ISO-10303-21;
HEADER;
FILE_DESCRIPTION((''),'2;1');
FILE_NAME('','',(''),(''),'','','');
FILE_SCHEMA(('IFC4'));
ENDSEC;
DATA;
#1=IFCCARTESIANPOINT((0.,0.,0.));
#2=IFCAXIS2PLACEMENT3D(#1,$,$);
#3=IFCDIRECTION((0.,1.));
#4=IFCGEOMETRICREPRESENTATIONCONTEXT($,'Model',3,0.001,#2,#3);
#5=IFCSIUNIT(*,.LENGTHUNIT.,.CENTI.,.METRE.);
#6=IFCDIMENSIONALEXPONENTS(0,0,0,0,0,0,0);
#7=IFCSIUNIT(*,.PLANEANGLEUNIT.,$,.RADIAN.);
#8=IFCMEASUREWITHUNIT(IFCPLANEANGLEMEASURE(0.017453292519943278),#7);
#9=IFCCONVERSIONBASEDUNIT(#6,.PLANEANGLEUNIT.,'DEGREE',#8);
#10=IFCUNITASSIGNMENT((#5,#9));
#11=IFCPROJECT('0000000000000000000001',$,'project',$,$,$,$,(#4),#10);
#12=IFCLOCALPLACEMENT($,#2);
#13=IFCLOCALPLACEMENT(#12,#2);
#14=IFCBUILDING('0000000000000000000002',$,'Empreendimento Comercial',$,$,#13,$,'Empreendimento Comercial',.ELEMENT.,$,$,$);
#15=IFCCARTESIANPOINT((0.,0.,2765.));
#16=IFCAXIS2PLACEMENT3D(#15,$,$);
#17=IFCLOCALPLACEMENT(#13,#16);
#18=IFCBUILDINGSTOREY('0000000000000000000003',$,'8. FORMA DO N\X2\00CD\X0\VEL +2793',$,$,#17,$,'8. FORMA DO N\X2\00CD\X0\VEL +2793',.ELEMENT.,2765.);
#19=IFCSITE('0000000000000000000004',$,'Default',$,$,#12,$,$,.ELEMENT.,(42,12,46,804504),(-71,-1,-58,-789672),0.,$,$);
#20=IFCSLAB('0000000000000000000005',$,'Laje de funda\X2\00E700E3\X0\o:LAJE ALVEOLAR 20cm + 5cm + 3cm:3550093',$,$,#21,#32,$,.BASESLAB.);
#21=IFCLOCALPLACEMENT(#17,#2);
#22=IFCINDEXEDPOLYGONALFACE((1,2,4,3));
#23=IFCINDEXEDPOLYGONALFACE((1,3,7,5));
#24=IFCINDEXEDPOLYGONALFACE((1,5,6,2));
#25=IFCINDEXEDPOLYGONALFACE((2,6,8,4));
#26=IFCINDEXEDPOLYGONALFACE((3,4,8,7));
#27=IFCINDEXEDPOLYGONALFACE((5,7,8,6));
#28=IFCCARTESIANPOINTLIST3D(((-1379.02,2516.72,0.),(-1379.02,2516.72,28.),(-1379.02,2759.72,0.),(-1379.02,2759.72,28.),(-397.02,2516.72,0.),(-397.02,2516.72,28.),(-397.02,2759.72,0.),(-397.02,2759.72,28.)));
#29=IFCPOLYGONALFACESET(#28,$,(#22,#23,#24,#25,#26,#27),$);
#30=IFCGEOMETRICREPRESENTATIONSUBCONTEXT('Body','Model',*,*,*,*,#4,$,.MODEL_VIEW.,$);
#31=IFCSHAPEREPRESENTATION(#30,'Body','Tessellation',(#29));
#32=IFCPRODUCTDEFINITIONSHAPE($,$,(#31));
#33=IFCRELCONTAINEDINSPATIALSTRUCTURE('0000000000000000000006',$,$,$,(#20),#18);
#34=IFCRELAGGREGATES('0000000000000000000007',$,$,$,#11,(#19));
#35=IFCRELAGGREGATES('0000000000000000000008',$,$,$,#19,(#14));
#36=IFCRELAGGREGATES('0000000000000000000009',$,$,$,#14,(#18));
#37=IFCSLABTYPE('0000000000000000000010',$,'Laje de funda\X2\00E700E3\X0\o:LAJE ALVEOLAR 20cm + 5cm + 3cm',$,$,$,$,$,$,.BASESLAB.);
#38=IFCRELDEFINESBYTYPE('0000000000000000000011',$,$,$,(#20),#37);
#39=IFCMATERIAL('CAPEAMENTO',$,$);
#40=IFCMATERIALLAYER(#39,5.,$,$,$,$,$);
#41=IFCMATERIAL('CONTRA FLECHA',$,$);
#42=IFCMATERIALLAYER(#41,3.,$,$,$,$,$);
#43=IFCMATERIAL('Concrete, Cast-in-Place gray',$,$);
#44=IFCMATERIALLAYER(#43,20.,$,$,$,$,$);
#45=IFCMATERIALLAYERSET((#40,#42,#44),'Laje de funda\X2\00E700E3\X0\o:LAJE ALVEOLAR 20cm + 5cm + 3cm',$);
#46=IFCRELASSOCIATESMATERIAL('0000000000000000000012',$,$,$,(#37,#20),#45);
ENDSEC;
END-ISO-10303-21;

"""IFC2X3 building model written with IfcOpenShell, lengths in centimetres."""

from ifc_helpers import new_model, entity, si_unit, converted_unit, direction, frame, frame_2d, origin, place, context, subcontext, project, spatial, rectangle, extrude, material, layer, layer_set, layer_usage, type_object, element, save


model = new_model("IFC2X3")

# Units and contexts
model_context = context("Model", 3, precision=0.001, world=origin(), true_north=direction((0.0, 1.0)))
body_context = subcontext(model_context, "Body", "Model", "MODEL_VIEW")
ifc_project = project(units=[si_unit("LENGTHUNIT", "METRE", prefix="CENTI"), converted_unit("PLANEANGLEUNIT", "DEGREE", entity("IfcPlaneAngleMeasure", 0.017453292519943278), si_unit("PLANEANGLEUNIT", "RADIAN"), dimensions=[0, 0, 0, 0, 0, 0, 0])], contexts=[model_context])

# Site, building, storey
site_placement = place(None, origin())
site = spatial("IfcSite", under=ifc_project, at=site_placement, Name="Default", CompositionType="ELEMENT", RefLatitude=(42, 12, 46, 804504), RefLongitude=(-71, -1, -58, -789672), RefElevation=0.0)
building_placement = place(site_placement, origin())
building = spatial("IfcBuilding", under=site, at=building_placement, Name="Empreendimento Comercial", LongName="Empreendimento Comercial", CompositionType="ELEMENT")
storey_placement = place(building_placement, frame((0.0, 0.0, 2765.0)))
storey = spatial("IfcBuildingStorey", under=building, at=storey_placement, Name="8. FORMA DO NÍVEL +2793", LongName="8. FORMA DO NÍVEL +2793", CompositionType="ELEMENT", Elevation=2765.0)

# Slab
ifc_material_1 = material(Name="CAPEAMENTO")
ifc_layer_1 = layer(ifc_material_1, 5.0)
ifc_material_2 = material(Name="CONTRA FLECHA")
ifc_layer_2 = layer(ifc_material_2, 3.0)
ifc_material_3 = material(Name="Concrete, Cast-in-Place gray")
ifc_layer_3 = layer(ifc_material_3, 20.0)
ifc_layer_set = layer_set([ifc_layer_1, ifc_layer_2, ifc_layer_3], Name="Laje de fundação:LAJE ALVEOLAR 20cm + 5cm + 3cm")
ifc_layer_usage = layer_usage(ifc_layer_set, "AXIS3", "POSITIVE", 0.0)
slab_type = type_object("IfcSlabType", Name="Laje de fundação:LAJE ALVEOLAR 20cm + 5cm + 3cm", PredefinedType="BASESLAB", material=ifc_layer_set)
slab_placement = place(storey_placement, origin())
element("IfcSlab", 1, at=slab_placement, inside=storey, type_object=slab_type, material=ifc_layer_usage, Name="Laje de fundação:LAJE ALVEOLAR 20cm + 5cm + 3cm:3550093", PredefinedType="BASESLAB", context=body_context, shape_type="SweptSolid", body=[
    extrude(rectangle(XDim=243.0, YDim=982.0, at=frame_2d((0.0, 0.0), x_axis=(1.0, 0.0))), frame((-888.02, 2638.22, 28.0), z_axis=(0.0, 0.0, -1.0), x_axis=(0.0, 1.0, 0.0)), (0.0, 0.0, 1.0), 28.0),
])

save(model, "model.ifc")
